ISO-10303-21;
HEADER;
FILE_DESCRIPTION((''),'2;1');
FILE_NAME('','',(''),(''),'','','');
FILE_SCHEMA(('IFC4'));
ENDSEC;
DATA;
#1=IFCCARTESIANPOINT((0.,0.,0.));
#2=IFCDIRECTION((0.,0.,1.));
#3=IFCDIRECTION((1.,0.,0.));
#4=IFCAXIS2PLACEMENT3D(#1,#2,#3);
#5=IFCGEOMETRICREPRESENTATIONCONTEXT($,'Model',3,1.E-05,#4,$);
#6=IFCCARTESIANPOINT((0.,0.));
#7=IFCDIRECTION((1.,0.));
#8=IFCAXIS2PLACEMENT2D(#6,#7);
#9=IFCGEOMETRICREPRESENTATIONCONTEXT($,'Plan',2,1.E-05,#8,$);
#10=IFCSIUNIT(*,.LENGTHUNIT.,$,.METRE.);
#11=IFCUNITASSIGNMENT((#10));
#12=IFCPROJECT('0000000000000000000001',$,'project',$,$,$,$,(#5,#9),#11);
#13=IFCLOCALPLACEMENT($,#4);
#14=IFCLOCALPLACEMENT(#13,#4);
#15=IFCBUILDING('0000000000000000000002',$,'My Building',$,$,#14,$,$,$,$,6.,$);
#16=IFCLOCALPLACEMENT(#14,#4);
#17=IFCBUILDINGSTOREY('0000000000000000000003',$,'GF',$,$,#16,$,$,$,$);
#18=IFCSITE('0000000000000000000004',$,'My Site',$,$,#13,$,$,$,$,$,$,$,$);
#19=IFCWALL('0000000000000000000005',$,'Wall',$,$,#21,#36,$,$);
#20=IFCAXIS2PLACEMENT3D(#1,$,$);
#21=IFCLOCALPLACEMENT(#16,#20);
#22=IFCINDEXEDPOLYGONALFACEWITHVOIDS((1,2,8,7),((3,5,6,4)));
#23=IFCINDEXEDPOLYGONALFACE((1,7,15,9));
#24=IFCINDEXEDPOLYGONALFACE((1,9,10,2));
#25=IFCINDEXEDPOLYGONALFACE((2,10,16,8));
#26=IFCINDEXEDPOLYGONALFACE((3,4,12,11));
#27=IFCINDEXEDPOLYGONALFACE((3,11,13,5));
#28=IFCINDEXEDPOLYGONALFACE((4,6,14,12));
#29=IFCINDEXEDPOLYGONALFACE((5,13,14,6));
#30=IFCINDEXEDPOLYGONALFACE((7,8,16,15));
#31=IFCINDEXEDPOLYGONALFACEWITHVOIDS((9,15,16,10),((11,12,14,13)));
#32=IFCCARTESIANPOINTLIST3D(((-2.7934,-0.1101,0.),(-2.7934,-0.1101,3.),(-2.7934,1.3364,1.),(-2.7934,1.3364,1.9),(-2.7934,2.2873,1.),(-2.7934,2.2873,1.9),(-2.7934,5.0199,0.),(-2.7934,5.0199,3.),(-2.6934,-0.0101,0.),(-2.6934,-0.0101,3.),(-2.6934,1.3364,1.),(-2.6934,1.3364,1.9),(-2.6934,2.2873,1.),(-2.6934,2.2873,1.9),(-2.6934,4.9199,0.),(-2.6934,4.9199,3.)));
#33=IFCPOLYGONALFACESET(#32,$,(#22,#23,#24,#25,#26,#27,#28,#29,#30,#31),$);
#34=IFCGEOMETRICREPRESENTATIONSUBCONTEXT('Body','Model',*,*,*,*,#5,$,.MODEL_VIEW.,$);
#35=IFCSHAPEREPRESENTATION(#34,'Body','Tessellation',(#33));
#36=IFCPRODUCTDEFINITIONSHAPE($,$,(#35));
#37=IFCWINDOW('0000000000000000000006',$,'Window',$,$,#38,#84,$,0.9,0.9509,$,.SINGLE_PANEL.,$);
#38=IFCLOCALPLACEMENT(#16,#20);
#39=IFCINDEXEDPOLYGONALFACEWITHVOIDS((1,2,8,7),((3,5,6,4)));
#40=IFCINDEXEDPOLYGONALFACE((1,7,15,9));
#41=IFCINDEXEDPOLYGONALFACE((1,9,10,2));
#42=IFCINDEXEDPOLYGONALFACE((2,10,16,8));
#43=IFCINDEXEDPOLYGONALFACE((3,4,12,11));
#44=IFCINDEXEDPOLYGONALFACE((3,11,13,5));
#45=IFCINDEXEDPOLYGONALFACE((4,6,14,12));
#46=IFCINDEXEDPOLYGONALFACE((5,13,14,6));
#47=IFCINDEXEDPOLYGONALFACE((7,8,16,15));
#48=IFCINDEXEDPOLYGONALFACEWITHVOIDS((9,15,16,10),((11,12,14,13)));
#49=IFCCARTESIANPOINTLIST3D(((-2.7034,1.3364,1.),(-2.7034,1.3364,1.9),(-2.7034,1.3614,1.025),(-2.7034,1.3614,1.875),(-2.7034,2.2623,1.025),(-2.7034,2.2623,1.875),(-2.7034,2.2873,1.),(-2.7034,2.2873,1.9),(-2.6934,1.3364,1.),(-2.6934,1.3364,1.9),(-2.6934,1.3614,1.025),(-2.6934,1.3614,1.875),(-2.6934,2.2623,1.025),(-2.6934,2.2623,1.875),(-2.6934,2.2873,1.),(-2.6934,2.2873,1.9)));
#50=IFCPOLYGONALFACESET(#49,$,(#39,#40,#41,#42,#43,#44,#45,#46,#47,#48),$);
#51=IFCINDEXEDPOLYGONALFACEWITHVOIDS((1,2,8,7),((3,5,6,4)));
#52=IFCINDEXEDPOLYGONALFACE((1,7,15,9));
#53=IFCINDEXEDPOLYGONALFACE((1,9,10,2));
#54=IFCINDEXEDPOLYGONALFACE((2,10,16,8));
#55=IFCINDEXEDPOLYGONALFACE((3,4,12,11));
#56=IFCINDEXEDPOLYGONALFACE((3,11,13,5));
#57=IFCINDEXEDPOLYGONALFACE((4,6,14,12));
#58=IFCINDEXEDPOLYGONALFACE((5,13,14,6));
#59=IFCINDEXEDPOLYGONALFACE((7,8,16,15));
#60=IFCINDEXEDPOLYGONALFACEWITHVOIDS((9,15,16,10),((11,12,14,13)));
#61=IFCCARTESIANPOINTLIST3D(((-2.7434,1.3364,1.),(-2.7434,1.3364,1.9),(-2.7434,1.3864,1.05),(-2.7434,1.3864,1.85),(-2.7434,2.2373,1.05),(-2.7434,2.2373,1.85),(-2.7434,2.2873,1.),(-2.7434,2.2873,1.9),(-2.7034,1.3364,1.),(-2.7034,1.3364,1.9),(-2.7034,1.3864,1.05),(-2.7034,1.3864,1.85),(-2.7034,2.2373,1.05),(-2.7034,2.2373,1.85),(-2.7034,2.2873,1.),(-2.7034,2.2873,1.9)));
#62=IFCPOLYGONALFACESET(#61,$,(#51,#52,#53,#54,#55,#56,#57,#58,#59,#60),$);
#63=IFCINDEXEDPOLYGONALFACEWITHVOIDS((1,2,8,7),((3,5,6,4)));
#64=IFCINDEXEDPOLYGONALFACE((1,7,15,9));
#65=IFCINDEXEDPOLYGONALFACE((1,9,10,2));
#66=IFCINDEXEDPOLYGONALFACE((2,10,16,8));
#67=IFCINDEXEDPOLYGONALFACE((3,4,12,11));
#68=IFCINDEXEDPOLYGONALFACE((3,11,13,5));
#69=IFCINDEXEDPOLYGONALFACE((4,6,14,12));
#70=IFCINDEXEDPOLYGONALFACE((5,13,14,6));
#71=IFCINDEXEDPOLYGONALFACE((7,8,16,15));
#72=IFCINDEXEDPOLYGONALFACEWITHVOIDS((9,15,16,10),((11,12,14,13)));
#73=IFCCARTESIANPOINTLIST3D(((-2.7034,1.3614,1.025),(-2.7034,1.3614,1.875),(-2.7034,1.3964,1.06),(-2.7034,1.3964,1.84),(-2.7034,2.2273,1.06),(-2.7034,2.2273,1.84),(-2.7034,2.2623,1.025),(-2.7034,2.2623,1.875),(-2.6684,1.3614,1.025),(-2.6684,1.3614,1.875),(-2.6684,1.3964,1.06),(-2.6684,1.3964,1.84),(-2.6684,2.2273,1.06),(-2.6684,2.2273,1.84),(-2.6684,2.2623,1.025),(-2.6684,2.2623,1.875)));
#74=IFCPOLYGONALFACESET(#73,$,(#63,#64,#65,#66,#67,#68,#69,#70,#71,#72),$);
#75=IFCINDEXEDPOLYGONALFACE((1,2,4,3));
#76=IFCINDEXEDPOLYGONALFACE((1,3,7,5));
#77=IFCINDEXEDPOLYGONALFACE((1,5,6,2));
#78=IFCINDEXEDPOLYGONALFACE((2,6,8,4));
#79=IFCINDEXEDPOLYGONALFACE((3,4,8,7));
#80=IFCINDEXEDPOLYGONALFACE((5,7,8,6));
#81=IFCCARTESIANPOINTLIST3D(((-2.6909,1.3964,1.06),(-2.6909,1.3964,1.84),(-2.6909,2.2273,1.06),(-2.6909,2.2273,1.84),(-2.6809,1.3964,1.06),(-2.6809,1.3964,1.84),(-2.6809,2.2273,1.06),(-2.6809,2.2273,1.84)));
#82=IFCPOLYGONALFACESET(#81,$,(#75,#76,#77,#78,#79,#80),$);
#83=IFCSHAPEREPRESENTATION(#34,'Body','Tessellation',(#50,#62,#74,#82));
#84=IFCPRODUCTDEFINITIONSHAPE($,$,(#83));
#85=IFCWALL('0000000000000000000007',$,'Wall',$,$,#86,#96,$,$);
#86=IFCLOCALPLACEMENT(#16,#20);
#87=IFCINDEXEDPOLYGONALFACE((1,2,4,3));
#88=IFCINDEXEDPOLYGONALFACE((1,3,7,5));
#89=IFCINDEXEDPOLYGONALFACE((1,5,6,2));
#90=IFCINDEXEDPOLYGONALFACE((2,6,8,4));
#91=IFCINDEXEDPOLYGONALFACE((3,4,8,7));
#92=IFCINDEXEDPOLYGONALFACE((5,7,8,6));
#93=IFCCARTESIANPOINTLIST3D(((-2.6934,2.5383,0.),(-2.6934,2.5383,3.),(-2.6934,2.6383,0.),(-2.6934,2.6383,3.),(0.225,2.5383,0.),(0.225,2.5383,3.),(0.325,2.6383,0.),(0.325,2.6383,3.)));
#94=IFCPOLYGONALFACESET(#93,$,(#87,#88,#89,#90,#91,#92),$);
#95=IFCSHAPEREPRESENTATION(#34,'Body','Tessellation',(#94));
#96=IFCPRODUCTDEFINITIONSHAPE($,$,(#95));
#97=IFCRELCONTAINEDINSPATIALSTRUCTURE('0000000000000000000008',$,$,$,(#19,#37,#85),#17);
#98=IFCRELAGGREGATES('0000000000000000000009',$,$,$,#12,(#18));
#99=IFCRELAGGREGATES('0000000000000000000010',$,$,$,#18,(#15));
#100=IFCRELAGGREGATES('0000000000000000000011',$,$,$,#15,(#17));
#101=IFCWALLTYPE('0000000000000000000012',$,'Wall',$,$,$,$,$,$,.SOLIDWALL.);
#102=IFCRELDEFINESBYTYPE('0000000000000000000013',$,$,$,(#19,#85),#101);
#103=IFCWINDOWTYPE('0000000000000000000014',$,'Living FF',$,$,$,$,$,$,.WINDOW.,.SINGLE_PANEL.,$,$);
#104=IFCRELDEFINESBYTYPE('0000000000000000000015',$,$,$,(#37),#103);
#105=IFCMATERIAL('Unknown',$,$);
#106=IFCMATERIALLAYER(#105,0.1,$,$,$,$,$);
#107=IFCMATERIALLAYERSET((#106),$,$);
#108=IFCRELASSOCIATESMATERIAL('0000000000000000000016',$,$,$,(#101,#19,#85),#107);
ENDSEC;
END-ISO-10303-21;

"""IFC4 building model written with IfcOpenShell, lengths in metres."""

from ifc_helpers import new_model, entity, si_unit, frame, origin_with_axes, origin_2d_with_axis, place, context, subcontext, project, spatial, line, indexed_curve, outline, extrude, shape, source, transform, mapped, material, layer, layer_set, layer_usage, type_object, type_shapes, element, fill, save


model = new_model("IFC4")

# Units and contexts
model_context = context("Model", 3, precision=1e-05, world=origin_with_axes())
plan_context = context("Plan", 2, precision=1e-05, world=origin_2d_with_axis())
body_context_1 = subcontext(model_context, "Body", "Model", "MODEL_VIEW")
body_context_2 = subcontext(plan_context, "Body", "Plan", "PLAN_VIEW")
ifc_project = project(units=[si_unit("LENGTHUNIT", "METRE")], contexts=[model_context, plan_context])

# Site, building, storey
site_placement = place(None, origin_with_axes())
site = spatial("IfcSite", under=ifc_project, at=site_placement, Name="My Site")
building_placement = place(site_placement, origin_with_axes())
building = spatial("IfcBuilding", under=site, at=building_placement, Name="My Building", ElevationOfTerrain=6.0)
storey_placement = place(building_placement, origin_with_axes())
storey = spatial("IfcBuildingStorey", under=building, at=storey_placement, Name="GF")

# Shared definitions
ifc_material_1 = material(Name="Unknown")
ifc_layer = layer(ifc_material_1, 0.1)
ifc_layer_set = layer_set([ifc_layer])
wall_type = type_object("IfcWallType", Name="Wall", PredefinedType="SOLIDWALL", material=ifc_layer_set)

# Wall, opening, window
ifc_layer_usage_1 = layer_usage(ifc_layer_set, "AXIS2", "POSITIVE", 0.0)
wall_1_placement = place(storey_placement, frame((-2.7934, 5.0199, 0.0), z_axis=(0.0, 0.0, 1.0), x_axis=(0.0, -1.0, 0.0)))
wall_1 = element("IfcWall", 1, at=wall_1_placement, inside=storey, type_object=wall_type, material=ifc_layer_usage_1, Name="Wall", context=body_context_1, shape_type="SweptSolid", body=[
    extrude(outline(indexed_curve([(0.0, 0.0), (0.1, 0.1), (5.03, 0.1), (5.13, 0.0)], segments=[line(1, 2, 3, 4, 1)])), origin_with_axes(), (0.0, 0.0, 1.0), 3.0),
])
shared_shape_1 = source(origin_with_axes(), body_context_1, "Body", "SweptSolid", [
    extrude(outline(indexed_curve([(0.0, 0.0), (0.9509, 0.0), (0.9509, 0.9), (0.0, 0.9)], segments=[line(1, 2, 3, 4, 1)])), frame((0.0, -0.6, 0.0), z_axis=(0.0, -1.0, 0.0), x_axis=(1.0, 0.0, 0.0)), (0.0, 0.0, -1.0), 1.2),
])
opening_1_placement = place(wall_1_placement, frame((2.7326, 0.0, 1.0), z_axis=(0.0, 0.0, 1.0), x_axis=(1.0, 0.0, 0.0)))
opening_1 = element("IfcOpeningElement", 2, at=opening_1_placement, cuts=wall_1, PredefinedType="OPENING", context=body_context_1, shape_type="MappedRepresentation", body=[
    mapped(shared_shape_1, transform((0.0, 0.0, 0.0), x_axis=(1.0, 0.0, 0.0), y_axis=(0.0, 1.0, 0.0), z_axis=(0.0, 0.0, 1.0), scale=1.0)),
])
window_type_1 = type_object("IfcWindowType", Name="Living FF", PartitioningType="SINGLE_PANEL", PredefinedType="WINDOW")
shared_shape_2 = source(origin_with_axes(), body_context_1, "Body", "SweptSolid", [
    extrude(outline(indexed_curve([(0.0, 0.0), (0.9509, 0.0), (0.9509, 0.9), (0.0, 0.9)], segments=[line(1, 2, 3, 4, 1)]), holes=[indexed_curve([(0.025, 0.025), (0.9259, 0.025), (0.9259, 0.875), (0.025, 0.875)], segments=[line(1, 2, 3, 4, 1)])]), frame((0.0, 0.09, 0.0), z_axis=(0.0, -1.0, 0.0), x_axis=(1.0, 0.0, 0.0)), (0.0, 0.0, -1.0), 0.01),
    extrude(outline(indexed_curve([(0.0, 0.0), (0.9509, 0.0), (0.9509, 0.9), (0.0, 0.9)], segments=[line(1, 2, 3, 4, 1)]), holes=[indexed_curve([(0.05, 0.05), (0.9009, 0.05), (0.9009, 0.85), (0.05, 0.85)], segments=[line(1, 2, 3, 4, 1)])]), frame((0.0, 0.05, 0.0), z_axis=(0.0, -1.0, 0.0), x_axis=(1.0, 0.0, 0.0)), (0.0, 0.0, -1.0), 0.04),
    extrude(outline(indexed_curve([(0.0, 0.0), (0.9009, 0.0), (0.9009, 0.85), (0.0, 0.85)], segments=[line(1, 2, 3, 4, 1)]), holes=[indexed_curve([(0.035, 0.035), (0.8659, 0.035), (0.8659, 0.815), (0.035, 0.815)], segments=[line(1, 2, 3, 4, 1)])]), frame((0.025, 0.09, 0.025), z_axis=(0.0, -1.0, 0.0), x_axis=(1.0, 0.0, 0.0)), (0.0, 0.0, -1.0), 0.035),
    extrude(outline(indexed_curve([(0.035, 0.035), (0.8659, 0.035), (0.8659, 0.815), (0.035, 0.815)], segments=[line(1, 2, 3, 4, 1)])), frame((0.025, 0.1025, 0.025), z_axis=(0.0, -1.0, 0.0), x_axis=(1.0, 0.0, 0.0)), (0.0, 0.0, -1.0), 0.01),
])
shared_shape_3 = source(origin_with_axes(), body_context_2, "Body", "Curve2D", [
    entity("IfcIndexedPolyCurve", entity("IfcCartesianPointList2D", [[0.05, 0.05], [0.9009, 0.05]])),
    entity("IfcIndexedPolyCurve", entity("IfcCartesianPointList2D", [[0.0, 0.1], [0.025, 0.1], [0.025, 0.09], [0.05, 0.09], [0.05, 0.05], [0.0, 0.05]]), [entity("IfcLineIndex", [1, 2, 3, 4, 5, 6, 1])]),
    entity("IfcIndexedPolyCurve", entity("IfcCartesianPointList2D", [[0.9509, 0.1], [0.9259, 0.1], [0.9259, 0.09], [0.9009, 0.09], [0.9009, 0.05], [0.9509, 0.05]]), [entity("IfcLineIndex", [1, 2, 3, 4, 5, 6, 1])]),
    entity("IfcIndexedPolyCurve", entity("IfcCartesianPointList2D", [[0.025, 0.09], [0.06, 0.09], [0.06, 0.125], [0.025, 0.125]]), [entity("IfcLineIndex", [1, 2, 3, 4, 1])]),
    entity("IfcIndexedPolyCurve", entity("IfcCartesianPointList2D", [[0.9259, 0.09], [0.8909, 0.09], [0.8909, 0.125], [0.9259, 0.125]]), [entity("IfcLineIndex", [1, 2, 3, 4, 1])]),
    entity("IfcIndexedPolyCurve", entity("IfcCartesianPointList2D", [[0.06, 0.09], [0.8909, 0.09]])),
    entity("IfcIndexedPolyCurve", entity("IfcCartesianPointList2D", [[0.06, 0.125], [0.8909, 0.125]])),
    entity("IfcIndexedPolyCurve", entity("IfcCartesianPointList2D", [[0.06, 0.1075], [0.8909, 0.1075]])),
])
type_shapes(window_type_1, [shared_shape_2, shared_shape_3])
window_1_placement = place(opening_1_placement, frame((0.0, 0.0, 0.0), z_axis=(0.0, 0.0, 1.0), x_axis=(1.0, 0.0, 0.0)))
window_1 = element("IfcWindow", 3, at=window_1_placement, inside=storey, type_object=window_type_1, Name="Window", OverallHeight=0.9, OverallWidth=0.9509, PartitioningType="SINGLE_PANEL", shapes=[
    shape(body_context_1, "Body", "MappedRepresentation", [mapped(shared_shape_2, transform((0.0, 0.0, 0.0), x_axis=(1.0, 0.0, 0.0), y_axis=(0.0, 1.0, 0.0), z_axis=(0.0, 0.0, 1.0), scale=1.0))]),
    shape(body_context_2, "Body", "MappedRepresentation", [mapped(shared_shape_3, transform((0.0, 0.0, 0.0), x_axis=(1.0, 0.0, 0.0), y_axis=(0.0, 1.0, 0.0), z_axis=(0.0, 0.0, 1.0), scale=1.0))]),
])
fill(opening_1, window_1)

# Wall
ifc_layer_usage_2 = layer_usage(ifc_layer_set, "AXIS2", "POSITIVE", 0.0)
wall_2_placement = place(storey_placement, frame((0.325, 2.6383, 0.0), z_axis=(0.0, 0.0, 1.0), x_axis=(-1.0, 0.0, 0.0)))
element("IfcWall", 4, at=wall_2_placement, inside=storey, type_object=wall_type, material=ifc_layer_usage_2, Name="Wall", context=body_context_1, shape_type="SweptSolid", body=[
    extrude(outline(indexed_curve([(0.0, 0.0), (0.1, 0.1), (3.0184, 0.1), (3.0184, 0.0)], segments=[line(1, 2, 3, 4, 1)])), origin_with_axes(), (0.0, 0.0, 1.0), 3.0),
])

save(model, "model.ifc")
